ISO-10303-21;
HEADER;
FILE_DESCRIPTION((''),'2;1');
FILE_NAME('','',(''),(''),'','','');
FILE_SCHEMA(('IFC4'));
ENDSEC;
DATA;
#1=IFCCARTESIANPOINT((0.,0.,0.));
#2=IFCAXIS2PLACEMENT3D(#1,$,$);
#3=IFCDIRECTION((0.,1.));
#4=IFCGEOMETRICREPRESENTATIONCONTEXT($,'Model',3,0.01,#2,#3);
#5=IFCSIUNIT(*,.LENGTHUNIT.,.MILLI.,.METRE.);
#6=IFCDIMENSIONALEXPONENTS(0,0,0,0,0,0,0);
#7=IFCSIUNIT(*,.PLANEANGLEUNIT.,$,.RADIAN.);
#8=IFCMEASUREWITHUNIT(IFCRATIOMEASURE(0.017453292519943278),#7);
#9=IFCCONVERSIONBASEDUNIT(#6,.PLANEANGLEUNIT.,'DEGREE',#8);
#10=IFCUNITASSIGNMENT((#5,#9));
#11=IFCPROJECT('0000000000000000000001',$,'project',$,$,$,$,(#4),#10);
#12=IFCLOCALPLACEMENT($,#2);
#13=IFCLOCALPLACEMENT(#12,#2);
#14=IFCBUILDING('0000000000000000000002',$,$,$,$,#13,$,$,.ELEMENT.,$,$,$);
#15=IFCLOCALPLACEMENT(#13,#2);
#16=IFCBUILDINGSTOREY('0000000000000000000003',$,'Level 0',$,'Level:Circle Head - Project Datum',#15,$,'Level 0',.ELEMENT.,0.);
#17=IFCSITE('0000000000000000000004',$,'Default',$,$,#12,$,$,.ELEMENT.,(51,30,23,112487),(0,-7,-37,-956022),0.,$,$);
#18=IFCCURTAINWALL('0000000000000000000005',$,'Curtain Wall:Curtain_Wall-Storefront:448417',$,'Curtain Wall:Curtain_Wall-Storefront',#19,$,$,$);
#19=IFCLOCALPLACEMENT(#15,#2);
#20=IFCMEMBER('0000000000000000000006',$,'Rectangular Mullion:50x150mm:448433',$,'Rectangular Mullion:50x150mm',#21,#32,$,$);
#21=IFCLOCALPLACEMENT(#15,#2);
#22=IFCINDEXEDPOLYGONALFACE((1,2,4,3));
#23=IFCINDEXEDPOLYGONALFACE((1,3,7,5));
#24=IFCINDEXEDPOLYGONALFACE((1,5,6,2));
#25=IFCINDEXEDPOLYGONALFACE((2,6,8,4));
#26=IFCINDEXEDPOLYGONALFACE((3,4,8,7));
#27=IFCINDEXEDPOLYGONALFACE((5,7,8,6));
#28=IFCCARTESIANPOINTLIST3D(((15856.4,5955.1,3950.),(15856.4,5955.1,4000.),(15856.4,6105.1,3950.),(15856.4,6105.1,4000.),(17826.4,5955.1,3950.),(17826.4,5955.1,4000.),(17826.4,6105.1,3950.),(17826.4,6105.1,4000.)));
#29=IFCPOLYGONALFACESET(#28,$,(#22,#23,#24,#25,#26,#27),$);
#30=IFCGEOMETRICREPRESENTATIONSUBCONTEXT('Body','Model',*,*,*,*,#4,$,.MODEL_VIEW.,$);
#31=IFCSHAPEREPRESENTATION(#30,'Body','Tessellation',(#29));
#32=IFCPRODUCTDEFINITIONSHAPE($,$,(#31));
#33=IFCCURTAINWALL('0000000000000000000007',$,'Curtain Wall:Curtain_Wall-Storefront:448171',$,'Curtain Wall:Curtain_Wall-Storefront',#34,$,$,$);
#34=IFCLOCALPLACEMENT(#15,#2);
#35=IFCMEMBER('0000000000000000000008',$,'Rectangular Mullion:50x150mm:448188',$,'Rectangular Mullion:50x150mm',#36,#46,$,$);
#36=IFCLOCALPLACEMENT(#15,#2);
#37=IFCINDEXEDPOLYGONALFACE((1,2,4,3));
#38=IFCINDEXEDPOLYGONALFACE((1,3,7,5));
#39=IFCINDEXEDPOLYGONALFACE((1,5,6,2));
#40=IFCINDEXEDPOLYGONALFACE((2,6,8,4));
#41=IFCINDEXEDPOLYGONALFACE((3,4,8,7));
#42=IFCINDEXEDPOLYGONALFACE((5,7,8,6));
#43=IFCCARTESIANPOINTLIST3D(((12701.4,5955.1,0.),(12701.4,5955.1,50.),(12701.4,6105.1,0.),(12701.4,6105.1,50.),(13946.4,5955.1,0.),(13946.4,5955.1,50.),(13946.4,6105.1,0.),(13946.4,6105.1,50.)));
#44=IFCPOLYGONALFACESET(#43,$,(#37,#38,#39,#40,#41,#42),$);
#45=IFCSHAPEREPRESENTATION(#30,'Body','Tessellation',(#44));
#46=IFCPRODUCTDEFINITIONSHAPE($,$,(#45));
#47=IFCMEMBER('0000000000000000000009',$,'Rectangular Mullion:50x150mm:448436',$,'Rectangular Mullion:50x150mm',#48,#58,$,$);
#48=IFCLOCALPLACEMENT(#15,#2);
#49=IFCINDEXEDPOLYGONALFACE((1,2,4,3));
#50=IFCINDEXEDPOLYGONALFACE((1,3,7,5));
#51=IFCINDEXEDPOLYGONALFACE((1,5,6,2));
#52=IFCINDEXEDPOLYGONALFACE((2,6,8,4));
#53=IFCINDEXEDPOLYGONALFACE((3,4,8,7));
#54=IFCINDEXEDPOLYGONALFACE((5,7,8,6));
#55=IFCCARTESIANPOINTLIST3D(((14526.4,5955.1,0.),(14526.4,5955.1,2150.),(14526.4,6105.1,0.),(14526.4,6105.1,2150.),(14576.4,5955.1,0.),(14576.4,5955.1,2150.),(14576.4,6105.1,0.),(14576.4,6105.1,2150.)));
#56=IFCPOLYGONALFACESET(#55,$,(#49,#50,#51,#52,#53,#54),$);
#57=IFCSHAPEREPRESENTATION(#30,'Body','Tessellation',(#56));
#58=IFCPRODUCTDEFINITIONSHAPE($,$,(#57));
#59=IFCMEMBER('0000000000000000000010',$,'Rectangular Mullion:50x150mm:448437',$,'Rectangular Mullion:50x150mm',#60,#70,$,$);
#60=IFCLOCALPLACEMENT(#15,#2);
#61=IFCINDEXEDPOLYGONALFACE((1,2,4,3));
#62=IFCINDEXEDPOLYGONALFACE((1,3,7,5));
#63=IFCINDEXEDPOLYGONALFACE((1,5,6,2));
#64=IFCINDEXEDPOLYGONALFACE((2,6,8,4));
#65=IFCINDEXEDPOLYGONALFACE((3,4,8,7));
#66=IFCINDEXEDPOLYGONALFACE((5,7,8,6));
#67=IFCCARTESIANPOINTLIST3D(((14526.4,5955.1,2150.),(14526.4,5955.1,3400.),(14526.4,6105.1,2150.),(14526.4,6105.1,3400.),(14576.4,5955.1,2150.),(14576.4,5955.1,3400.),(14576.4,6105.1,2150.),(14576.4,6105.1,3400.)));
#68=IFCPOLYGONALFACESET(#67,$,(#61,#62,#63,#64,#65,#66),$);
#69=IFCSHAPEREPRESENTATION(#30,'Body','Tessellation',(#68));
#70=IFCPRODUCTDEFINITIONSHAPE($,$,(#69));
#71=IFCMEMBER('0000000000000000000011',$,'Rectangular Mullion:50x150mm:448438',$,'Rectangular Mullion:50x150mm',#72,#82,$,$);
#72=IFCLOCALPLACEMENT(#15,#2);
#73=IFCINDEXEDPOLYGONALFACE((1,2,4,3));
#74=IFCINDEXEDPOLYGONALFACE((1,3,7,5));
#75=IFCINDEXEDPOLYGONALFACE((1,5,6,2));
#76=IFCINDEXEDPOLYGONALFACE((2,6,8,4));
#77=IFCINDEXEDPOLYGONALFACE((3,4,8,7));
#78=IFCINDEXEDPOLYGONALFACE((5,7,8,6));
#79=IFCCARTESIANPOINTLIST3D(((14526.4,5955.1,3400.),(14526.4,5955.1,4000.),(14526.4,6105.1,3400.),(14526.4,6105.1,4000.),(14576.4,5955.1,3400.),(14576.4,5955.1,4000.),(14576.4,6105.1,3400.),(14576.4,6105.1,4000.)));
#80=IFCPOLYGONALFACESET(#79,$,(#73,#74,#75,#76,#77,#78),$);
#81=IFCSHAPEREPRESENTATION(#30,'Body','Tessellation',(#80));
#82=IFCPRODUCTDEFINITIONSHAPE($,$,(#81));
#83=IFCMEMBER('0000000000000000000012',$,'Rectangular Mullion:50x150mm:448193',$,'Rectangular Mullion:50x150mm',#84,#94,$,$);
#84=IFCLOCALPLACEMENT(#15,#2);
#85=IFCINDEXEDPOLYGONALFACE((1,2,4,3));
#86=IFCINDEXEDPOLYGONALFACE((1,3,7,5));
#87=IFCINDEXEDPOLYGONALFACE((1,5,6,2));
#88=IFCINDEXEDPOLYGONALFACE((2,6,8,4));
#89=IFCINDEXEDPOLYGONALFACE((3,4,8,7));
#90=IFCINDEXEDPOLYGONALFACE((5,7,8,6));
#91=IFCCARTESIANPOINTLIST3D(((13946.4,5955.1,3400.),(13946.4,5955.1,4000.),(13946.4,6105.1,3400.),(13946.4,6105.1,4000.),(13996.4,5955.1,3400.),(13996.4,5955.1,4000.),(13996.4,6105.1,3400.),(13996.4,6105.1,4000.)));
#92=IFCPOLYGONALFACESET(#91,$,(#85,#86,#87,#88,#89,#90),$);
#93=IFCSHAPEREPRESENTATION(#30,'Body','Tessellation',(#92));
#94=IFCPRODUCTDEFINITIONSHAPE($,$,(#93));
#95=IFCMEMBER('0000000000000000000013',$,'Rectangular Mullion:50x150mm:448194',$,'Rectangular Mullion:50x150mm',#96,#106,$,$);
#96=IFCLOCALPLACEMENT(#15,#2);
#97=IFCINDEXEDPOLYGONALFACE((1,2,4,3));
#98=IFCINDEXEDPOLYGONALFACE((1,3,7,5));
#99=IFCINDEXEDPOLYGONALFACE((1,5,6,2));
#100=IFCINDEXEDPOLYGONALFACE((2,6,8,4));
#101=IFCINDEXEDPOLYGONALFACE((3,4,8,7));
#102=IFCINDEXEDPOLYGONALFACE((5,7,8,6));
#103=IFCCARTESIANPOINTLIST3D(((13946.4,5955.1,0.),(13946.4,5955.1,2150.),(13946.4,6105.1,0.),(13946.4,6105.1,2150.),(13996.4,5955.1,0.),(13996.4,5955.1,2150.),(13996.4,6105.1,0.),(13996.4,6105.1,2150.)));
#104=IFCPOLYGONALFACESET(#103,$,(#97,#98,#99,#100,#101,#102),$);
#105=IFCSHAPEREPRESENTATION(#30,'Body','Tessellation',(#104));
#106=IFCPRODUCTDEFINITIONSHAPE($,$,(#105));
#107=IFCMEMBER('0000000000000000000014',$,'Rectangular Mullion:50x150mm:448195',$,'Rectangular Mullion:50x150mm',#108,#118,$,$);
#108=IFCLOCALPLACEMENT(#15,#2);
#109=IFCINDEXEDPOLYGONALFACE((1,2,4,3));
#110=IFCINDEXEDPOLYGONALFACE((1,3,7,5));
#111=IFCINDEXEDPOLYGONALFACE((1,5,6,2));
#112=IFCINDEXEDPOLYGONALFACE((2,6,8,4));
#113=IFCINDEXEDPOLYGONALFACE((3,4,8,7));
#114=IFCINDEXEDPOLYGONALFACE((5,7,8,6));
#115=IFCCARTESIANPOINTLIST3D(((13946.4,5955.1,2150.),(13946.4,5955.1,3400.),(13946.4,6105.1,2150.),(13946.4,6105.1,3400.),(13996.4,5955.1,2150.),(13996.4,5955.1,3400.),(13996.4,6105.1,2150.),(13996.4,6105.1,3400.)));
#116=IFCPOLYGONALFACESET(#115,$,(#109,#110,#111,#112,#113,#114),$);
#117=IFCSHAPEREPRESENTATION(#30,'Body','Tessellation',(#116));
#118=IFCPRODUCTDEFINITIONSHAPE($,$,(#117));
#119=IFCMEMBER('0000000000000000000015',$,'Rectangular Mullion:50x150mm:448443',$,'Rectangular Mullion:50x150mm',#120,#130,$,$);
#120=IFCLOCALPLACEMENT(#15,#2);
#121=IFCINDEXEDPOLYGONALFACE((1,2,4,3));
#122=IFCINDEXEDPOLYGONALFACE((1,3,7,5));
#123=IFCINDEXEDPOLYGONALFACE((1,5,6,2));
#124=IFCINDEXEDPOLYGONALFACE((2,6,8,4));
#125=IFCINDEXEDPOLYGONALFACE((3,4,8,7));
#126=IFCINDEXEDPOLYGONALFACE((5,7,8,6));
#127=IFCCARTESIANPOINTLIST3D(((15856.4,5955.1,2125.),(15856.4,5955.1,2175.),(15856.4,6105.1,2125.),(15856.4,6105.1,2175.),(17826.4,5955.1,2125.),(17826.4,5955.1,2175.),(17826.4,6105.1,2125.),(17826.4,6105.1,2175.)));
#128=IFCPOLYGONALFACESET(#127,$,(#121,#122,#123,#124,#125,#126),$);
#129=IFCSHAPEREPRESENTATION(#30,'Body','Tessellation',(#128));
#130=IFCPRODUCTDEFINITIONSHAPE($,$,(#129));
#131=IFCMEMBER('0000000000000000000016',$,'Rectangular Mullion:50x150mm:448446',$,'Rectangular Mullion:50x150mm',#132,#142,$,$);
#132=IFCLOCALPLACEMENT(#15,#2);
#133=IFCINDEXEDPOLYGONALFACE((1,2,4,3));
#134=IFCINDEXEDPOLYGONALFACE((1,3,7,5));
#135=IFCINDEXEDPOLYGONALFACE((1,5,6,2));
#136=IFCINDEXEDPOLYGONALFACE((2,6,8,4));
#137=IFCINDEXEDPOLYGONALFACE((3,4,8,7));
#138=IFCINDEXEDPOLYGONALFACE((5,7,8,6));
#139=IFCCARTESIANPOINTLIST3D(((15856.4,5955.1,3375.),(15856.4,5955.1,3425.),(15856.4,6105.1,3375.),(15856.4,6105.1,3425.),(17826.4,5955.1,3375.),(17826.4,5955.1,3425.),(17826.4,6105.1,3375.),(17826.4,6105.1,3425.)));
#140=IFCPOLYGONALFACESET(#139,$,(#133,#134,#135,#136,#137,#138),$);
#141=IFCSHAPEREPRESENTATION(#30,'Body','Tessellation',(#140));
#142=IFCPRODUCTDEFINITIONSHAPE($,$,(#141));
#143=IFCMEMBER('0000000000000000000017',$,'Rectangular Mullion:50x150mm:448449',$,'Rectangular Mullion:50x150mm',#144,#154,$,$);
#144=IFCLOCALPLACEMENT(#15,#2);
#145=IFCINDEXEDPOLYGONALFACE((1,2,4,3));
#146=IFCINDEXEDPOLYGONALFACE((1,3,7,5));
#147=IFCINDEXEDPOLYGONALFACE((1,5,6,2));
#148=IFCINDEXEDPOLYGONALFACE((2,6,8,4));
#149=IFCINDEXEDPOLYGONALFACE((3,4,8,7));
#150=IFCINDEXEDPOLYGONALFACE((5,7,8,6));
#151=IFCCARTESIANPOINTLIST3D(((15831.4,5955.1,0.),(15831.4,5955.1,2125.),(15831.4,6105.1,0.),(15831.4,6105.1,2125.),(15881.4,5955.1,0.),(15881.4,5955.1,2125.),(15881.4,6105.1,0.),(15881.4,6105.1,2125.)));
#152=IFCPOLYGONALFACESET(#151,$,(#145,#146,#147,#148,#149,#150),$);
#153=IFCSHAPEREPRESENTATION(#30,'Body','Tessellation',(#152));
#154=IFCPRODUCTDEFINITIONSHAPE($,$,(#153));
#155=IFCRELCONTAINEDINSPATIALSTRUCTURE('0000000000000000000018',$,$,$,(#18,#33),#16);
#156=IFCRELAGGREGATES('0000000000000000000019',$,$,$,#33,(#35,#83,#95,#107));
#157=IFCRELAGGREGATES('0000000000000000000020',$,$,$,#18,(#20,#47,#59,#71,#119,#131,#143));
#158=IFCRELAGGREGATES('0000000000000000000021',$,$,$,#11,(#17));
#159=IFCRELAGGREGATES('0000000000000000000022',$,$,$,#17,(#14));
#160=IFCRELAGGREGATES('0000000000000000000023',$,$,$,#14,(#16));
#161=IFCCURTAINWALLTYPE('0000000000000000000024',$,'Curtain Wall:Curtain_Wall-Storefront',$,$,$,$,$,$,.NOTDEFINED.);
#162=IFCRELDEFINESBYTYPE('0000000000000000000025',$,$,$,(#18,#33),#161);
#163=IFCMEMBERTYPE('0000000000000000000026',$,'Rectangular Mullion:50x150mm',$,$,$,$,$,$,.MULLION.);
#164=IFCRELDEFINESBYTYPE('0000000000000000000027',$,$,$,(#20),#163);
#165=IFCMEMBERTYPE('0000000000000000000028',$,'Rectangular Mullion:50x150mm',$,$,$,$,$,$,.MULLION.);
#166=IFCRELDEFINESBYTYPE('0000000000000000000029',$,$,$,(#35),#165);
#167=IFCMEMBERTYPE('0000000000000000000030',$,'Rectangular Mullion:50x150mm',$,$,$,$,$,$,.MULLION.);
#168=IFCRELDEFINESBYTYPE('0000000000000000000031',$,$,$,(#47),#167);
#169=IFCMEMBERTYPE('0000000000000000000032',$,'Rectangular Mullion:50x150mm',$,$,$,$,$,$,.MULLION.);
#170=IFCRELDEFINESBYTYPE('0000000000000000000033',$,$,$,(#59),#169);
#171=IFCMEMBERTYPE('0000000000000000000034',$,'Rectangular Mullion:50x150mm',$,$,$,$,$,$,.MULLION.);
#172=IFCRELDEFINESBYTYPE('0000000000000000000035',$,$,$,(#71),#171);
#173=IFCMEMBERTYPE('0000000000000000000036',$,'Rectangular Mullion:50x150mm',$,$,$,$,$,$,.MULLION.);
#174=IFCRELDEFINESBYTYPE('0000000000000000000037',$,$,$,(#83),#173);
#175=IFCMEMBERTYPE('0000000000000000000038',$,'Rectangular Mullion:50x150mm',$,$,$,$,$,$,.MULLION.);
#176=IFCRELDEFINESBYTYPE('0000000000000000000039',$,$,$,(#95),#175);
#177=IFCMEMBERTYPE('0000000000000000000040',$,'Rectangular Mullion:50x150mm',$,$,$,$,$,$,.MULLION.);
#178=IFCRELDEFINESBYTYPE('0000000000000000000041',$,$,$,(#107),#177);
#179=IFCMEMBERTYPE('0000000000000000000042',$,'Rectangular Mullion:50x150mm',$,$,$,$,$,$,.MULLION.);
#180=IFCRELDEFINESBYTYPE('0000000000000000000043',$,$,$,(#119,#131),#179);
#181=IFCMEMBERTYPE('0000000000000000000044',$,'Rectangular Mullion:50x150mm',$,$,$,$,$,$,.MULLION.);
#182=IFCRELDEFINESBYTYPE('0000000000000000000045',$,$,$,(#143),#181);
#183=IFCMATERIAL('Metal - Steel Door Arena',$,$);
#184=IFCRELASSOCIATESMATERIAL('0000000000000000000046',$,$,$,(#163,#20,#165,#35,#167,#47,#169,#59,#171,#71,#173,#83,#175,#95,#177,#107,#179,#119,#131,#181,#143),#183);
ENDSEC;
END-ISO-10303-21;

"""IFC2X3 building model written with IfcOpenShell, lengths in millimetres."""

from ifc_helpers import new_model, entity, si_unit, converted_unit, direction, frame, origin, origin_2d_with_axis, place, context, subcontext, project, spatial, rectangle, extrude, source, transform, mapped, material, type_object, type_shapes, element, aggregate, save


model = new_model("IFC2X3")

# Units and contexts
model_context = context("Model", 3, precision=0.01, world=origin(), true_north=direction((0.0, 1.0)))
body_context = subcontext(model_context, "Body", "Model", "MODEL_VIEW")
ifc_project = project(units=[si_unit("LENGTHUNIT", "METRE", prefix="MILLI"), converted_unit("PLANEANGLEUNIT", "DEGREE", entity("IfcRatioMeasure", 0.017453292519943278), si_unit("PLANEANGLEUNIT", "RADIAN"), dimensions=[0, 0, 0, 0, 0, 0, 0])], contexts=[model_context])

# Site, building, storey
site_placement = place(None, origin())
site = spatial("IfcSite", under=ifc_project, at=site_placement, Name="Default", CompositionType="ELEMENT", RefLatitude=(51, 30, 23, 112487), RefLongitude=(0, -7, -37, -956022), RefElevation=0.0)
building_placement = place(site_placement, origin())
building = spatial("IfcBuilding", under=site, at=building_placement, CompositionType="ELEMENT")
storey_placement = place(building_placement, origin())
storey = spatial("IfcBuildingStorey", under=building, at=storey_placement, Name="Level 0", ObjectType="Level:Circle Head - Project Datum", LongName="Level 0", CompositionType="ELEMENT", Elevation=0.0)

# Curtain walls, members
curtain_wall_type = type_object("IfcCurtainWallType", Name="Curtain Wall:Curtain_Wall-Storefront", PredefinedType="NOTDEFINED")
curtain_wall_1_placement = place(storey_placement, origin())
curtain_wall_1 = element("IfcCurtainWall", 1, at=curtain_wall_1_placement, inside=storey, type_object=curtain_wall_type, Name="Curtain Wall:Curtain_Wall-Storefront:448417", ObjectType="Curtain Wall:Curtain_Wall-Storefront")
ifc_material_1 = material(Name="Metal - Steel Door Arena")
member_type_1 = type_object("IfcMemberType", Name="Rectangular Mullion:50x150mm", PredefinedType="MULLION", material=ifc_material_1)
shared_shape_1 = source(origin(), body_context, "Body", "SweptSolid", [
    extrude(rectangle(XDim=150.0, YDim=50.0, at=origin_2d_with_axis()), frame((-25.0, 0.0, -1970.0), z_axis=(0.0, 0.0, 1.0), x_axis=(0.0, -1.0, 0.0)), (0.0, 0.0, 1.0), 1970.0),
])
type_shapes(member_type_1, [shared_shape_1])
member_1_placement = place(curtain_wall_1_placement, frame((15856.4, 6030.1, 4000.0), z_axis=(-1.0, 0.0, 0.0), x_axis=(0.0, 0.0, 1.0)))
member_1 = element("IfcMember", 2, at=member_1_placement, type_object=member_type_1, material=ifc_material_1, Name="Rectangular Mullion:50x150mm:448433", ObjectType="Rectangular Mullion:50x150mm", context=body_context, shape_type="MappedRepresentation", body=[
    mapped(shared_shape_1, transform((0.0, 0.0, 0.0), scale=1.0)),
])
curtain_wall_2_placement = place(storey_placement, origin())
curtain_wall_2 = element("IfcCurtainWall", 3, at=curtain_wall_2_placement, inside=storey, type_object=curtain_wall_type, Name="Curtain Wall:Curtain_Wall-Storefront:448171", ObjectType="Curtain Wall:Curtain_Wall-Storefront")
member_type_2 = type_object("IfcMemberType", Name="Rectangular Mullion:50x150mm", PredefinedType="MULLION", material=ifc_material_1)
shared_shape_2 = source(origin(), body_context, "Body", "SweptSolid", [
    extrude(rectangle(XDim=150.0, YDim=50.0, at=origin_2d_with_axis()), frame((-25.0, 0.0, -1245.0), z_axis=(0.0, 0.0, 1.0), x_axis=(0.0, -1.0, 0.0)), (0.0, 0.0, 1.0), 1245.0),
])
type_shapes(member_type_2, [shared_shape_2])
member_2_placement = place(curtain_wall_2_placement, frame((13946.4, 6030.1, 0.0), z_axis=(1.0, 0.0, 0.0), x_axis=(0.0, 0.0, -1.0)))
member_2 = element("IfcMember", 4, at=member_2_placement, type_object=member_type_2, material=ifc_material_1, Name="Rectangular Mullion:50x150mm:448188", ObjectType="Rectangular Mullion:50x150mm", context=body_context, shape_type="MappedRepresentation", body=[
    mapped(shared_shape_2, transform((0.0, 0.0, 0.0), scale=1.0)),
])

# Members
member_type_3 = type_object("IfcMemberType", Name="Rectangular Mullion:50x150mm", PredefinedType="MULLION", material=ifc_material_1)
shared_shape_3 = source(origin(), body_context, "Body", "SweptSolid", [
    extrude(rectangle(XDim=150.0, YDim=50.0, at=origin_2d_with_axis()), frame((-25.0, 0.0, -2150.0), z_axis=(0.0, 0.0, 1.0), x_axis=(0.0, -1.0, 0.0)), (0.0, 0.0, 1.0), 2150.0),
])
type_shapes(member_type_3, [shared_shape_3])
member_3_placement = place(curtain_wall_1_placement, frame((14526.4, 6030.1, 0.0), z_axis=(0.0, 0.0, -1.0), x_axis=(-1.0, 0.0, 0.0)))
member_3 = element("IfcMember", 5, at=member_3_placement, type_object=member_type_3, material=ifc_material_1, Name="Rectangular Mullion:50x150mm:448436", ObjectType="Rectangular Mullion:50x150mm", context=body_context, shape_type="MappedRepresentation", body=[
    mapped(shared_shape_3, transform((0.0, 0.0, 0.0), scale=1.0)),
])
member_type_4 = type_object("IfcMemberType", Name="Rectangular Mullion:50x150mm", PredefinedType="MULLION", material=ifc_material_1)
shared_shape_4 = source(origin(), body_context, "Body", "SweptSolid", [
    extrude(rectangle(XDim=150.0, YDim=50.0, at=origin_2d_with_axis()), frame((-25.0, 0.0, -1250.0), z_axis=(0.0, 0.0, 1.0), x_axis=(0.0, -1.0, 0.0)), (0.0, 0.0, 1.0), 1250.0),
])
type_shapes(member_type_4, [shared_shape_4])
member_4_placement = place(curtain_wall_1_placement, frame((14526.4, 6030.1, 2150.0), z_axis=(0.0, 0.0, -1.0), x_axis=(-1.0, 0.0, 0.0)))
member_4 = element("IfcMember", 6, at=member_4_placement, type_object=member_type_4, material=ifc_material_1, Name="Rectangular Mullion:50x150mm:448437", ObjectType="Rectangular Mullion:50x150mm", context=body_context, shape_type="MappedRepresentation", body=[
    mapped(shared_shape_4, transform((0.0, 0.0, 0.0), scale=1.0)),
])
member_type_5 = type_object("IfcMemberType", Name="Rectangular Mullion:50x150mm", PredefinedType="MULLION", material=ifc_material_1)
shared_shape_5 = source(origin(), body_context, "Body", "SweptSolid", [
    extrude(rectangle(XDim=150.0, YDim=50.0, at=origin_2d_with_axis()), frame((-25.0, 0.0, -600.0), z_axis=(0.0, 0.0, 1.0), x_axis=(0.0, -1.0, 0.0)), (0.0, 0.0, 1.0), 600.0),
])
type_shapes(member_type_5, [shared_shape_5])
member_5_placement = place(curtain_wall_1_placement, frame((14526.4, 6030.1, 3400.0), z_axis=(0.0, 0.0, -1.0), x_axis=(-1.0, 0.0, 0.0)))
member_5 = element("IfcMember", 7, at=member_5_placement, type_object=member_type_5, material=ifc_material_1, Name="Rectangular Mullion:50x150mm:448438", ObjectType="Rectangular Mullion:50x150mm", context=body_context, shape_type="MappedRepresentation", body=[
    mapped(shared_shape_5, transform((0.0, 0.0, 0.0), scale=1.0)),
])
member_type_6 = type_object("IfcMemberType", Name="Rectangular Mullion:50x150mm", PredefinedType="MULLION", material=ifc_material_1)
shared_shape_6 = source(origin(), body_context, "Body", "SweptSolid", [
    extrude(rectangle(XDim=150.0, YDim=50.0, at=origin_2d_with_axis()), frame((-25.0, 0.0, -600.0), z_axis=(0.0, 0.0, 1.0), x_axis=(0.0, -1.0, 0.0)), (0.0, 0.0, 1.0), 600.0),
])
type_shapes(member_type_6, [shared_shape_6])
member_6_placement = place(curtain_wall_2_placement, frame((13996.4, 6030.1, 4000.0)))
member_6 = element("IfcMember", 8, at=member_6_placement, type_object=member_type_6, material=ifc_material_1, Name="Rectangular Mullion:50x150mm:448193", ObjectType="Rectangular Mullion:50x150mm", context=body_context, shape_type="MappedRepresentation", body=[
    mapped(shared_shape_6, transform((0.0, 0.0, 0.0), scale=1.0)),
])
member_type_7 = type_object("IfcMemberType", Name="Rectangular Mullion:50x150mm", PredefinedType="MULLION", material=ifc_material_1)
shared_shape_7 = source(origin(), body_context, "Body", "SweptSolid", [
    extrude(rectangle(XDim=150.0, YDim=50.0, at=origin_2d_with_axis()), frame((-25.0, 0.0, -2150.0), z_axis=(0.0, 0.0, 1.0), x_axis=(0.0, -1.0, 0.0)), (0.0, 0.0, 1.0), 2150.0),
])
type_shapes(member_type_7, [shared_shape_7])
member_7_placement = place(curtain_wall_2_placement, frame((13996.4, 6030.1, 2150.0)))
member_7 = element("IfcMember", 9, at=member_7_placement, type_object=member_type_7, material=ifc_material_1, Name="Rectangular Mullion:50x150mm:448194", ObjectType="Rectangular Mullion:50x150mm", context=body_context, shape_type="MappedRepresentation", body=[
    mapped(shared_shape_7, transform((0.0, 0.0, 0.0), scale=1.0)),
])
member_type_8 = type_object("IfcMemberType", Name="Rectangular Mullion:50x150mm", PredefinedType="MULLION", material=ifc_material_1)
shared_shape_8 = source(origin(), body_context, "Body", "SweptSolid", [
    extrude(rectangle(XDim=150.0, YDim=50.0, at=origin_2d_with_axis()), frame((-25.0, 0.0, -1250.0), z_axis=(0.0, 0.0, 1.0), x_axis=(0.0, -1.0, 0.0)), (0.0, 0.0, 1.0), 1250.0),
])
type_shapes(member_type_8, [shared_shape_8])
member_8_placement = place(curtain_wall_2_placement, frame((13996.4, 6030.1, 3400.0)))
member_8 = element("IfcMember", 10, at=member_8_placement, type_object=member_type_8, material=ifc_material_1, Name="Rectangular Mullion:50x150mm:448195", ObjectType="Rectangular Mullion:50x150mm", context=body_context, shape_type="MappedRepresentation", body=[
    mapped(shared_shape_8, transform((0.0, 0.0, 0.0), scale=1.0)),
])
member_type_9 = type_object("IfcMemberType", Name="Rectangular Mullion:50x150mm", PredefinedType="MULLION", material=ifc_material_1)
shared_shape_9 = source(origin(), body_context, "Body", "SweptSolid", [
    extrude(rectangle(XDim=150.0, YDim=50.0, at=origin_2d_with_axis()), frame((0.0, 0.0, -1970.0), z_axis=(0.0, 0.0, 1.0), x_axis=(0.0, -1.0, 0.0)), (0.0, 0.0, 1.0), 1970.0),
])
type_shapes(member_type_9, [shared_shape_9])
member_9_placement = place(curtain_wall_1_placement, frame((15856.4, 6030.1, 2150.0), z_axis=(-1.0, 0.0, 0.0), x_axis=(0.0, 0.0, 1.0)))
member_9 = element("IfcMember", 11, at=member_9_placement, type_object=member_type_9, material=ifc_material_1, Name="Rectangular Mullion:50x150mm:448443", ObjectType="Rectangular Mullion:50x150mm", context=body_context, shape_type="MappedRepresentation", body=[
    mapped(shared_shape_9, transform((0.0, 0.0, 0.0), scale=1.0)),
])
member_10_placement = place(curtain_wall_1_placement, frame((15856.4, 6030.1, 3400.0), z_axis=(-1.0, 0.0, 0.0), x_axis=(0.0, 0.0, 1.0)))
member_10 = element("IfcMember", 12, at=member_10_placement, type_object=member_type_9, material=ifc_material_1, Name="Rectangular Mullion:50x150mm:448446", ObjectType="Rectangular Mullion:50x150mm", context=body_context, shape_type="MappedRepresentation", body=[
    mapped(shared_shape_9, transform((0.0, 0.0, 0.0), scale=1.0)),
])
member_type_10 = type_object("IfcMemberType", Name="Rectangular Mullion:50x150mm", PredefinedType="MULLION", material=ifc_material_1)
shared_shape_10 = source(origin(), body_context, "Body", "SweptSolid", [
    extrude(rectangle(XDim=150.0, YDim=50.0, at=origin_2d_with_axis()), frame((0.0, 0.0, -2125.0), z_axis=(0.0, 0.0, 1.0), x_axis=(0.0, -1.0, 0.0)), (0.0, 0.0, 1.0), 2125.0),
])
type_shapes(member_type_10, [shared_shape_10])
member_11_placement = place(curtain_wall_1_placement, frame((15856.4, 6030.1, 0.0), z_axis=(0.0, 0.0, -1.0), x_axis=(-1.0, 0.0, 0.0)))
member_11 = element("IfcMember", 13, at=member_11_placement, type_object=member_type_10, material=ifc_material_1, Name="Rectangular Mullion:50x150mm:448449", ObjectType="Rectangular Mullion:50x150mm", context=body_context, shape_type="MappedRepresentation", body=[
    mapped(shared_shape_10, transform((0.0, 0.0, 0.0), scale=1.0)),
])

aggregate(curtain_wall_2, [member_2, member_6, member_7, member_8])
aggregate(curtain_wall_1, [member_1, member_3, member_4, member_5, member_9, member_10, member_11])

save(model, "model.ifc")
